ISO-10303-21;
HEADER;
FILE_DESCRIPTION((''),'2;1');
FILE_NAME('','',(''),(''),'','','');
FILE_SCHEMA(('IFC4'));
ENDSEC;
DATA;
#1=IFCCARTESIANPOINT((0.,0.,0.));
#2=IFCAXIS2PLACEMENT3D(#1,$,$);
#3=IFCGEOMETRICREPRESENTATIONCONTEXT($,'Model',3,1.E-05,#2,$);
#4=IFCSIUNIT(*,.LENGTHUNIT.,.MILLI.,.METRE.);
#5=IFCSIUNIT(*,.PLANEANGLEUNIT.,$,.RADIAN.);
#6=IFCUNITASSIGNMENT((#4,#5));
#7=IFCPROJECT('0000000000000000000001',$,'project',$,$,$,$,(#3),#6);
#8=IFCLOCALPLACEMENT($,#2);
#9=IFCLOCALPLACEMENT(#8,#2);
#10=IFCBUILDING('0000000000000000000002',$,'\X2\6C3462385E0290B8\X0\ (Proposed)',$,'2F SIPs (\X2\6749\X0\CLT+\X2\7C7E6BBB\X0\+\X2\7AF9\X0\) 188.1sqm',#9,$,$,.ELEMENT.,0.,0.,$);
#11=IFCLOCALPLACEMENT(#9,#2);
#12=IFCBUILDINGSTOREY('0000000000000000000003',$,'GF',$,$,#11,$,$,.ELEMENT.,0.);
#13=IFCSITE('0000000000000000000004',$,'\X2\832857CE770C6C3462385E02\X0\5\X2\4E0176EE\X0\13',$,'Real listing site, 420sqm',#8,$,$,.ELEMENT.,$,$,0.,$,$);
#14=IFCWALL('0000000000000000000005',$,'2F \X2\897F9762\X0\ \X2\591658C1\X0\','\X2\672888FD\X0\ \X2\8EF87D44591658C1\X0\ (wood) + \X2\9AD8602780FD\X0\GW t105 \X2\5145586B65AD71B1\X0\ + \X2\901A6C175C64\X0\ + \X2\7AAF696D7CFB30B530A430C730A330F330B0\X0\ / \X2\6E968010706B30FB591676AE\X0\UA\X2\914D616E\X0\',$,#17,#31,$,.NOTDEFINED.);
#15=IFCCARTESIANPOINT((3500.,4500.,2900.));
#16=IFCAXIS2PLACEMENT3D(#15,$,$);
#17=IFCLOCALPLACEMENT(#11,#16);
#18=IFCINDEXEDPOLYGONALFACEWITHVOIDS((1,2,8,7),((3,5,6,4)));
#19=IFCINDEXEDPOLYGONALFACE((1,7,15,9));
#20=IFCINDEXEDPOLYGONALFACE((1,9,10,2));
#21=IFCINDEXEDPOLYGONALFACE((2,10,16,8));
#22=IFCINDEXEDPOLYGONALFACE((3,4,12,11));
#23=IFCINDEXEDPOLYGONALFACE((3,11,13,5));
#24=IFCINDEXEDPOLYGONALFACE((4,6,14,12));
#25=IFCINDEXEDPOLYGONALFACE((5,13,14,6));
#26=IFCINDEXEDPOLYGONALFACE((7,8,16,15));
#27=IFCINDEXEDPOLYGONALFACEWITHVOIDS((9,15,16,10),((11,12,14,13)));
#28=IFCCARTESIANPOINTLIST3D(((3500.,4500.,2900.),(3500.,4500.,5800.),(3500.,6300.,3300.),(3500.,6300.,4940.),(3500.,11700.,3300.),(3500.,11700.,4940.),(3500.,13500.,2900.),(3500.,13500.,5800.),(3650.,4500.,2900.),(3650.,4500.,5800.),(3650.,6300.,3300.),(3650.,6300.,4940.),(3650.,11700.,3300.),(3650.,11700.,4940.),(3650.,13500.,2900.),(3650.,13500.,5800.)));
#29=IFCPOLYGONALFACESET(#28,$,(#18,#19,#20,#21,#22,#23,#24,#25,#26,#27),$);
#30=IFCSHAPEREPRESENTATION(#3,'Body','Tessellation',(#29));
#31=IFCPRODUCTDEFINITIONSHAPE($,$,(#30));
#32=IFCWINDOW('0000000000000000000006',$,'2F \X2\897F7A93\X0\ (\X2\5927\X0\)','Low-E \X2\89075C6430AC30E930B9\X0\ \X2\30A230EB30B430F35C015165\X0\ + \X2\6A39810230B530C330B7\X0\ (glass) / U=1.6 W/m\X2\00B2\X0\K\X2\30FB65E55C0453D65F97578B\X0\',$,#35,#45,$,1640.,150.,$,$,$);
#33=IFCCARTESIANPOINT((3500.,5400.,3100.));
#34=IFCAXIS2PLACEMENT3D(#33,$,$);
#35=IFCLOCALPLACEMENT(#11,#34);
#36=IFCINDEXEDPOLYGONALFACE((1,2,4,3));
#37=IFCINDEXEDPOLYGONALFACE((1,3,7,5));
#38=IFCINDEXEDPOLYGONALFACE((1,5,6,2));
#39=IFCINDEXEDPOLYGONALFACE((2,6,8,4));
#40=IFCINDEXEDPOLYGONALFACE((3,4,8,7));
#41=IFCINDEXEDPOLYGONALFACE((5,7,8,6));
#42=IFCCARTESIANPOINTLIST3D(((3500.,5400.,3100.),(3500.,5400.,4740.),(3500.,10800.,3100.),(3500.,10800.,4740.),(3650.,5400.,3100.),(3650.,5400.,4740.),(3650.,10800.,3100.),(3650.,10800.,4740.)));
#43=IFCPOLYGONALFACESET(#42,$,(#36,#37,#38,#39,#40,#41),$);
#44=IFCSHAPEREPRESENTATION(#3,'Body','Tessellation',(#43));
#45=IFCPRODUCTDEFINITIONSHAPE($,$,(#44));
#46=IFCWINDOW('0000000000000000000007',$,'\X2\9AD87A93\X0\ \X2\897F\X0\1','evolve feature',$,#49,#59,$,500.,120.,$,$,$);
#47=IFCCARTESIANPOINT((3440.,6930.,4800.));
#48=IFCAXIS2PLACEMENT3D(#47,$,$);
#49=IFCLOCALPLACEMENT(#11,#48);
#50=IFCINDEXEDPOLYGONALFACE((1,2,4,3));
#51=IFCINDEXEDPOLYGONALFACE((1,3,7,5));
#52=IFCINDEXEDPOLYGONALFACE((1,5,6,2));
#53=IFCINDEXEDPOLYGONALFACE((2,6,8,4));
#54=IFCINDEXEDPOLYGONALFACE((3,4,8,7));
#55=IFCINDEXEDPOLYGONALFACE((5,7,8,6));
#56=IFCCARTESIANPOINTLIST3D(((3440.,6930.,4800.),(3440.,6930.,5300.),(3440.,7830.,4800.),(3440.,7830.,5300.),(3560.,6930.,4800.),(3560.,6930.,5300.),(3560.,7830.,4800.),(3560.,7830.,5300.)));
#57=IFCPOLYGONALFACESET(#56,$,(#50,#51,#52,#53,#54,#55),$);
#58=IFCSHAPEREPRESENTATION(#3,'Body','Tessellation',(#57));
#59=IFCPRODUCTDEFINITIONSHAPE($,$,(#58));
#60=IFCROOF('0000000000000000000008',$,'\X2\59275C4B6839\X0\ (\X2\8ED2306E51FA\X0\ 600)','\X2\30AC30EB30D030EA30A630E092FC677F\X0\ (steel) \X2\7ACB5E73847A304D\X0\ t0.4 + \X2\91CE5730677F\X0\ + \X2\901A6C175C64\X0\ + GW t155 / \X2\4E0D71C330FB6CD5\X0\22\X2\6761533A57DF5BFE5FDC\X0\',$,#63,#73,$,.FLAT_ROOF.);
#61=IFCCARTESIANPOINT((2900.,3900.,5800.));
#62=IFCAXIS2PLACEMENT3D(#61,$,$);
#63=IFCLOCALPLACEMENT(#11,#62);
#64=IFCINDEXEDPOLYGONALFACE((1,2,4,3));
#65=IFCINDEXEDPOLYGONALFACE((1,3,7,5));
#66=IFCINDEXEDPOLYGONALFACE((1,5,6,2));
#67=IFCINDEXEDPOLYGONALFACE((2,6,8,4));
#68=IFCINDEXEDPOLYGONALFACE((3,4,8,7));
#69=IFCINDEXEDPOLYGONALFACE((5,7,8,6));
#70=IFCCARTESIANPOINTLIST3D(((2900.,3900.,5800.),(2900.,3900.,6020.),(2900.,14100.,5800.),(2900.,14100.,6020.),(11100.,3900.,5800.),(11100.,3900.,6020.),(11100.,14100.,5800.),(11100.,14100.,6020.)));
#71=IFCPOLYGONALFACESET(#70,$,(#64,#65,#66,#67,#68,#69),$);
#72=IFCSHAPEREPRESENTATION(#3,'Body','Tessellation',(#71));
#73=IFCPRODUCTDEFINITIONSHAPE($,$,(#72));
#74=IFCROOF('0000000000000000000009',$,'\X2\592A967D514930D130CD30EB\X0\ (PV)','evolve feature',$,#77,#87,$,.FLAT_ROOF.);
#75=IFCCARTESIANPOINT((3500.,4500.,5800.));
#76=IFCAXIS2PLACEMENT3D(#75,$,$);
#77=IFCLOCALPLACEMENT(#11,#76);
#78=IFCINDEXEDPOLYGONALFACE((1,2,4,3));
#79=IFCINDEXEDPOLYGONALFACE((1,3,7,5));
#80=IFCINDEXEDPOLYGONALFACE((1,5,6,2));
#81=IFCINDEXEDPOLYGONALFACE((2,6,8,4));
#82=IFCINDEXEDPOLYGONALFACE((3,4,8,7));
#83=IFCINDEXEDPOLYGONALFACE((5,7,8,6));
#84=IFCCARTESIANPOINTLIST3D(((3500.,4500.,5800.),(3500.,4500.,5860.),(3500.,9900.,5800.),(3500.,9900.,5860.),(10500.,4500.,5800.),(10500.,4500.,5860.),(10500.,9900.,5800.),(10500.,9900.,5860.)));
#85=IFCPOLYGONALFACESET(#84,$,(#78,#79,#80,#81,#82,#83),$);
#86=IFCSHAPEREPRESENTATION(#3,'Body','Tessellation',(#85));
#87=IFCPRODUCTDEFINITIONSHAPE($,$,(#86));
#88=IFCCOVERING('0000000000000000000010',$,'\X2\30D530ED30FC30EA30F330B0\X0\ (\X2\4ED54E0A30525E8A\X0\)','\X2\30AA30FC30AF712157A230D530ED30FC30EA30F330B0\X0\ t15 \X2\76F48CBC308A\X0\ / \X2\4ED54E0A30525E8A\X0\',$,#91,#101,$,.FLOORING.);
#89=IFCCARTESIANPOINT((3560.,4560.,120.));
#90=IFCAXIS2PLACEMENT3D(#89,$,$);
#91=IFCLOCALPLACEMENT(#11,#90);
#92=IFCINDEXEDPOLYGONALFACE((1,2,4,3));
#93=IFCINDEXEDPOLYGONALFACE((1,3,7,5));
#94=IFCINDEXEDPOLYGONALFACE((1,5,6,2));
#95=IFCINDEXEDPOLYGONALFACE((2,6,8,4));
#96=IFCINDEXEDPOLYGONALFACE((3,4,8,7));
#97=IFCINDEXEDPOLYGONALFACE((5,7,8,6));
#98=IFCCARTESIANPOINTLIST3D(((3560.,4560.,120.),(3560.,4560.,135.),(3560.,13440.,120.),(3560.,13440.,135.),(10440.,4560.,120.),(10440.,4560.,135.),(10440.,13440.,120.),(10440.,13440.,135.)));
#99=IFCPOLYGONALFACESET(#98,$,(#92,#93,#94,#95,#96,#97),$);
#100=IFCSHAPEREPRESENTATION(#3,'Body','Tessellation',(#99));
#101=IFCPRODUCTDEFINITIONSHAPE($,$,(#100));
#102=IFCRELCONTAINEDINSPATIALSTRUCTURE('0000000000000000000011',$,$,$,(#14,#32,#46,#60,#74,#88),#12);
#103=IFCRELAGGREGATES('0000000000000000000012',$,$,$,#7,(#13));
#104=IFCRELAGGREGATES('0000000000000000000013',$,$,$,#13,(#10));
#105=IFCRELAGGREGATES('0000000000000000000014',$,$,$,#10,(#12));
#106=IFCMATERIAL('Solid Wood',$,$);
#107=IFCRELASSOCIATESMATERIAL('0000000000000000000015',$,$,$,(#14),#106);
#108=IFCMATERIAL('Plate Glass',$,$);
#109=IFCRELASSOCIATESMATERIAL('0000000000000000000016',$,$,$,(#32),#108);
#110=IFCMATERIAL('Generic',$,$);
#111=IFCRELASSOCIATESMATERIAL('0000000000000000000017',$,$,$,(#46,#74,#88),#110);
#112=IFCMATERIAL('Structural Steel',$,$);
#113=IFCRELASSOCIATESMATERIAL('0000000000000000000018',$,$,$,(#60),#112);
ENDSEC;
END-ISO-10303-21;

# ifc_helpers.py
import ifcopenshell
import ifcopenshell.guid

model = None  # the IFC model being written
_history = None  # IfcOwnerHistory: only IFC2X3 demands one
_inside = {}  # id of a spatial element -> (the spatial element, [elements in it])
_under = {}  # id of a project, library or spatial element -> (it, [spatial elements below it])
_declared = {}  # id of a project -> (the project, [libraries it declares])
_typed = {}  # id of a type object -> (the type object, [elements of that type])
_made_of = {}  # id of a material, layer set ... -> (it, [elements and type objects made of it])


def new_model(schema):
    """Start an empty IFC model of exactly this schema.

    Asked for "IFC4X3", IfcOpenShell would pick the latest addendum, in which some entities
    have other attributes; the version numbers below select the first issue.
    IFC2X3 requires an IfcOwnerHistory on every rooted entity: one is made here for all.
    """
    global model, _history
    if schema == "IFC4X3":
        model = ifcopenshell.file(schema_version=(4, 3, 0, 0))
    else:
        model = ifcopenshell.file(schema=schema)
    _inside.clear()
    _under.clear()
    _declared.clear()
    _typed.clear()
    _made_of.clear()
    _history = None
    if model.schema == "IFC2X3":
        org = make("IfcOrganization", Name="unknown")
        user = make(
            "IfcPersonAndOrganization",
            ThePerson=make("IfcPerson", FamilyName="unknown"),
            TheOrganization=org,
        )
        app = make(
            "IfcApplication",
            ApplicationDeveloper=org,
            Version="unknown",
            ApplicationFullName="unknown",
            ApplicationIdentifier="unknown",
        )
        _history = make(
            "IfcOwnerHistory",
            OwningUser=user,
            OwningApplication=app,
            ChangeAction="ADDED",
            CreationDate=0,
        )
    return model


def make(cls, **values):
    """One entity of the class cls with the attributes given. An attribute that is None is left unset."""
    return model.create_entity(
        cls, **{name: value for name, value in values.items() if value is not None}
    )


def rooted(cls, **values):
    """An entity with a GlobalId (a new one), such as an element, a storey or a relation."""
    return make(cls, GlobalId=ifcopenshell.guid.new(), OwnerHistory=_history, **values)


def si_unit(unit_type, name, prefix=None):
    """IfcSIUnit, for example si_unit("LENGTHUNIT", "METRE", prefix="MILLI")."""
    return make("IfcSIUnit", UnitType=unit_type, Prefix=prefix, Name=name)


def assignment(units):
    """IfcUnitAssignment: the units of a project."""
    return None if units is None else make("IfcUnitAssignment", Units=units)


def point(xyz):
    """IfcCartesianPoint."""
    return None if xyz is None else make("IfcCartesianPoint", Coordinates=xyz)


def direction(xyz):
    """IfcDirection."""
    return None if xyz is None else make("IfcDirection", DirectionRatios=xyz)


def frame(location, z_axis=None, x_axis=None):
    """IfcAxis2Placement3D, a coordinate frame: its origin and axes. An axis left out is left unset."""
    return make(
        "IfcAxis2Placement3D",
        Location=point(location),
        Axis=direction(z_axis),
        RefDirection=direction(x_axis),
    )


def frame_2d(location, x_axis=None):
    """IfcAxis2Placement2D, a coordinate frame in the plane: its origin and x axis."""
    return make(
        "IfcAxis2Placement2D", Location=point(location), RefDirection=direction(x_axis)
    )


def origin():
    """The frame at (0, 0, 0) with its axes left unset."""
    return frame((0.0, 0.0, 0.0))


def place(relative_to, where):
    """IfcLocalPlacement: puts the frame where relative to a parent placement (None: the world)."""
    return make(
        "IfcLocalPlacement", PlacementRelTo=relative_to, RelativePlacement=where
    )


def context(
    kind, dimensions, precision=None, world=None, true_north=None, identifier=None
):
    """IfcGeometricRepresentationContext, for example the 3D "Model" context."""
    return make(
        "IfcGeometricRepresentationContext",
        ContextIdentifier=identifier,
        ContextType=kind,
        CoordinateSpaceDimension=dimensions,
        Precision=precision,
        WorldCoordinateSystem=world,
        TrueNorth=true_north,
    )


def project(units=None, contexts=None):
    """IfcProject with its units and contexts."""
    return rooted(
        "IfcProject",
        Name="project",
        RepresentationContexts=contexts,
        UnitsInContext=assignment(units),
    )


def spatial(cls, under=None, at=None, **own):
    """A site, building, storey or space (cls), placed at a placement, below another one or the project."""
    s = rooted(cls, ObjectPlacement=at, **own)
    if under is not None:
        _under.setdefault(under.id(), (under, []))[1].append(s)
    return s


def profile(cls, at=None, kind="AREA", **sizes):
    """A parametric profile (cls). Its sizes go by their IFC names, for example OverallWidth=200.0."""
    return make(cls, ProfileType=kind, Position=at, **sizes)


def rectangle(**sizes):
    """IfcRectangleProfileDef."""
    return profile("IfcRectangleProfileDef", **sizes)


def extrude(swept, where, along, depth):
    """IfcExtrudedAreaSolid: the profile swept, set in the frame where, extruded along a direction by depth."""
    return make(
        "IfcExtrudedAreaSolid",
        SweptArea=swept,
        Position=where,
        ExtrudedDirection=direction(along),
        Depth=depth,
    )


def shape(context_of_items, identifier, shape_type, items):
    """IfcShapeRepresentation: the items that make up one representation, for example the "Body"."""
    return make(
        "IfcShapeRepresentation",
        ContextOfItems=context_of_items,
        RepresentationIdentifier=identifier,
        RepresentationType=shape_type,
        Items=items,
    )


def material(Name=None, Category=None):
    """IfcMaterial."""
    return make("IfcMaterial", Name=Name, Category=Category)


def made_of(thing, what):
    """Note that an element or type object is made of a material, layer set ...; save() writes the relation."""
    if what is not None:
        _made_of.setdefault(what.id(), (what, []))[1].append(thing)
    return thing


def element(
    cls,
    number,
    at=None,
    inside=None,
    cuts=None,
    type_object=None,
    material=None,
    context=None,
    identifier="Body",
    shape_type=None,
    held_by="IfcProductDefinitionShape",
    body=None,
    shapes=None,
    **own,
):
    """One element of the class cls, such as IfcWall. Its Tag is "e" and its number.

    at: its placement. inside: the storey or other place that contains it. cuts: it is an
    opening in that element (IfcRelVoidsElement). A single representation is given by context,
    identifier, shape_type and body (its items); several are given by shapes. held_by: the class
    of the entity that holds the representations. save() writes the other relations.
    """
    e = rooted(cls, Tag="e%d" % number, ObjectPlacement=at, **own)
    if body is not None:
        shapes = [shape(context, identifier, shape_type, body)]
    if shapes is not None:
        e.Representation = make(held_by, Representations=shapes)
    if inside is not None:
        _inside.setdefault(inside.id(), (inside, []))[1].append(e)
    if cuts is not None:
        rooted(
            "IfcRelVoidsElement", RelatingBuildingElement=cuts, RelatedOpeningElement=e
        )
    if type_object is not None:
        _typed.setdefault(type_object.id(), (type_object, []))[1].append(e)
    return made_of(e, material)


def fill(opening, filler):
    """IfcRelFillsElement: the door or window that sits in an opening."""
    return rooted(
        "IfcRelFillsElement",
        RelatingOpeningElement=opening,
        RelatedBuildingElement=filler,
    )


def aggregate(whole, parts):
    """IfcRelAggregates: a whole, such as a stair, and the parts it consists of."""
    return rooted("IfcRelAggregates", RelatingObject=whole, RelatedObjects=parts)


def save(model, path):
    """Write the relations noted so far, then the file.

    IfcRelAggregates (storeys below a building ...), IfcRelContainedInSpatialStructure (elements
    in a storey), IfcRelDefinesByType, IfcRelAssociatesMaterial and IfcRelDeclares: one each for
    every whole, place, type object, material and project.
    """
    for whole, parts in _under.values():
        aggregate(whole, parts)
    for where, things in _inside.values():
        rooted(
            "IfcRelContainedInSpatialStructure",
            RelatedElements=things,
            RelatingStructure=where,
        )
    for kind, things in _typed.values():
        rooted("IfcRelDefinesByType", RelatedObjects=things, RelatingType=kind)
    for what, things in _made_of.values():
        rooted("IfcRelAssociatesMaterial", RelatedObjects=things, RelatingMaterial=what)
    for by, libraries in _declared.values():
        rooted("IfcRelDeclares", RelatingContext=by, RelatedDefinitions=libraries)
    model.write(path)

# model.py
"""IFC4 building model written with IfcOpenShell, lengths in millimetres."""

from ifc_helpers import new_model, si_unit, frame, frame_2d, origin, place, context, project, spatial, rectangle, extrude, material, element, fill, save


model = new_model("IFC4")

# Units and contexts
model_context = context("Model", 3, precision=1e-05, world=origin())
ifc_project = project(units=[si_unit("LENGTHUNIT", "METRE", prefix="MILLI"), si_unit("PLANEANGLEUNIT", "RADIAN")], contexts=[model_context])

# Site, building, storey
site_placement = place(None, origin())
site = spatial("IfcSite", under=ifc_project, at=site_placement, Name="茨城県水戸市5丁目13", ObjectType="Real listing site, 420sqm", CompositionType="ELEMENT", RefElevation=0.0)
building_placement = place(site_placement, origin())
building = spatial("IfcBuilding", under=site, at=building_placement, Name="水戸市邸 (Proposed)", ObjectType="2F SIPs (杉CLT+籾殻+竹) 188.1sqm", CompositionType="ELEMENT", ElevationOfRefHeight=0.0, ElevationOfTerrain=0.0)
storey_placement = place(building_placement, origin())
storey = spatial("IfcBuildingStorey", under=building, at=storey_placement, Name="GF", CompositionType="ELEMENT", Elevation=0.0)

# Shared definitions
ifc_material_1 = material(Name="Solid Wood")

# Shared definitions
ifc_material_2 = material(Name="Plate Glass")
ifc_material_3 = material(Name="Generic")

# Wall, openings, windows
wall_1_placement = place(storey_placement, frame((3500.0, 4500.0, 2900.0)))
wall_1 = element("IfcWall", 1, at=wall_1_placement, inside=storey, material=ifc_material_1, Name="2F 西面 外壁", Description="木製 軸組外壁 (wood) + 高性能GW t105 充填断熱 + 通気層 + 窯業系サイディング / 準耐火・外皮UA配慮", PredefinedType="NOTDEFINED", context=model_context, shape_type="SweptSolid", body=[
    extrude(rectangle(XDim=150.0, YDim=9000.0, at=frame_2d((75.0, 4500.0))), frame((3500.0, 4500.0, 2900.0)), (0.0, 0.0, 1.0), 2900.0),
])
opening_1_placement = place(storey_placement, frame((3500.0, 5400.0, 3100.0)))
opening_1 = element("IfcOpeningElement", 2, at=opening_1_placement, cuts=wall_1, PredefinedType="NOTDEFINED", context=model_context, shape_type="SweptSolid", body=[
    extrude(rectangle(XDim=150.0, YDim=5400.0, at=frame_2d((75.0, 2700.0))), frame((3500.0, 5400.0, 3100.0)), (0.0, 0.0, 1.0), 1640.0),
])
opening_2_placement = place(storey_placement, frame((3440.0, 6930.0, 4800.0)))
opening_2 = element("IfcOpeningElement", 3, at=opening_2_placement, cuts=wall_1, PredefinedType="NOTDEFINED", context=model_context, shape_type="SweptSolid", body=[
    extrude(rectangle(XDim=120.0, YDim=900.0, at=frame_2d((60.0, 450.0))), frame((3440.0, 6930.0, 4800.0)), (0.0, 0.0, 1.0), 500.0),
])
window_1_placement = place(storey_placement, frame((3500.0, 5400.0, 3100.0)))
window_1 = element("IfcWindow", 4, at=window_1_placement, inside=storey, material=ifc_material_2, Name="2F 西窓 (大)", Description="Low-E 複層ガラス アルゴン封入 + 樹脂サッシ (glass) / U=1.6 W/m²K・日射取得型", OverallHeight=1640.0, OverallWidth=150.0, context=model_context, shape_type="SweptSolid", body=[
    extrude(rectangle(XDim=150.0, YDim=5400.0, at=frame_2d((75.0, 2700.0))), frame((3500.0, 5400.0, 3100.0)), (0.0, 0.0, 1.0), 1640.0),
])
fill(opening_1, window_1)
window_2_placement = place(storey_placement, frame((3440.0, 6930.0, 4800.0)))
window_2 = element("IfcWindow", 5, at=window_2_placement, inside=storey, material=ifc_material_3, Name="高窓 西1", Description="evolve feature", OverallHeight=500.0, OverallWidth=120.0, context=model_context, shape_type="SweptSolid", body=[
    extrude(rectangle(XDim=120.0, YDim=900.0, at=frame_2d((60.0, 450.0))), frame((3440.0, 6930.0, 4800.0)), (0.0, 0.0, 1.0), 500.0),
])
fill(opening_2, window_2)

# Roofs
ifc_material_4 = material(Name="Structural Steel")
roof_1_placement = place(storey_placement, frame((2900.0, 3900.0, 5800.0)))
element("IfcRoof", 6, at=roof_1_placement, inside=storey, material=ifc_material_4, Name="大屋根 (軒の出 600)", Description="ガルバリウム鋼板 (steel) 立平葺き t0.4 + 野地板 + 通気層 + GW t155 / 不燃・法22条区域対応", PredefinedType="FLAT_ROOF", context=model_context, shape_type="SweptSolid", body=[
    extrude(rectangle(XDim=8200.0, YDim=10200.0, at=frame_2d((4100.0, 5100.0))), frame((2900.0, 3900.0, 5800.0)), (0.0, 0.0, 1.0), 220.0),
])
roof_2_placement = place(storey_placement, frame((3500.0, 4500.0, 5800.0)))
element("IfcRoof", 7, at=roof_2_placement, inside=storey, material=ifc_material_3, Name="太陽光パネル (PV)", Description="evolve feature", PredefinedType="FLAT_ROOF", context=model_context, shape_type="SweptSolid", body=[
    extrude(rectangle(XDim=7000.0, YDim=5400.0, at=frame_2d((3500.0, 2700.0))), frame((3500.0, 4500.0, 5800.0)), (0.0, 0.0, 1.0), 60.0),
])

# Covering
covering_placement = place(storey_placement, frame((3560.0, 4560.0, 120.0)))
element("IfcCovering", 8, at=covering_placement, inside=storey, material=ifc_material_3, Name="フローリング (仕上げ床)", Description="オーク無垢フローリング t15 直貼り / 仕上げ床", PredefinedType="FLOORING", context=model_context, shape_type="SweptSolid", body=[
    extrude(rectangle(XDim=6880.0, YDim=8880.0, at=frame_2d((3440.0, 4440.0))), frame((3560.0, 4560.0, 120.0)), (0.0, 0.0, 1.0), 15.0),
])

save(model, "model.ifc")
